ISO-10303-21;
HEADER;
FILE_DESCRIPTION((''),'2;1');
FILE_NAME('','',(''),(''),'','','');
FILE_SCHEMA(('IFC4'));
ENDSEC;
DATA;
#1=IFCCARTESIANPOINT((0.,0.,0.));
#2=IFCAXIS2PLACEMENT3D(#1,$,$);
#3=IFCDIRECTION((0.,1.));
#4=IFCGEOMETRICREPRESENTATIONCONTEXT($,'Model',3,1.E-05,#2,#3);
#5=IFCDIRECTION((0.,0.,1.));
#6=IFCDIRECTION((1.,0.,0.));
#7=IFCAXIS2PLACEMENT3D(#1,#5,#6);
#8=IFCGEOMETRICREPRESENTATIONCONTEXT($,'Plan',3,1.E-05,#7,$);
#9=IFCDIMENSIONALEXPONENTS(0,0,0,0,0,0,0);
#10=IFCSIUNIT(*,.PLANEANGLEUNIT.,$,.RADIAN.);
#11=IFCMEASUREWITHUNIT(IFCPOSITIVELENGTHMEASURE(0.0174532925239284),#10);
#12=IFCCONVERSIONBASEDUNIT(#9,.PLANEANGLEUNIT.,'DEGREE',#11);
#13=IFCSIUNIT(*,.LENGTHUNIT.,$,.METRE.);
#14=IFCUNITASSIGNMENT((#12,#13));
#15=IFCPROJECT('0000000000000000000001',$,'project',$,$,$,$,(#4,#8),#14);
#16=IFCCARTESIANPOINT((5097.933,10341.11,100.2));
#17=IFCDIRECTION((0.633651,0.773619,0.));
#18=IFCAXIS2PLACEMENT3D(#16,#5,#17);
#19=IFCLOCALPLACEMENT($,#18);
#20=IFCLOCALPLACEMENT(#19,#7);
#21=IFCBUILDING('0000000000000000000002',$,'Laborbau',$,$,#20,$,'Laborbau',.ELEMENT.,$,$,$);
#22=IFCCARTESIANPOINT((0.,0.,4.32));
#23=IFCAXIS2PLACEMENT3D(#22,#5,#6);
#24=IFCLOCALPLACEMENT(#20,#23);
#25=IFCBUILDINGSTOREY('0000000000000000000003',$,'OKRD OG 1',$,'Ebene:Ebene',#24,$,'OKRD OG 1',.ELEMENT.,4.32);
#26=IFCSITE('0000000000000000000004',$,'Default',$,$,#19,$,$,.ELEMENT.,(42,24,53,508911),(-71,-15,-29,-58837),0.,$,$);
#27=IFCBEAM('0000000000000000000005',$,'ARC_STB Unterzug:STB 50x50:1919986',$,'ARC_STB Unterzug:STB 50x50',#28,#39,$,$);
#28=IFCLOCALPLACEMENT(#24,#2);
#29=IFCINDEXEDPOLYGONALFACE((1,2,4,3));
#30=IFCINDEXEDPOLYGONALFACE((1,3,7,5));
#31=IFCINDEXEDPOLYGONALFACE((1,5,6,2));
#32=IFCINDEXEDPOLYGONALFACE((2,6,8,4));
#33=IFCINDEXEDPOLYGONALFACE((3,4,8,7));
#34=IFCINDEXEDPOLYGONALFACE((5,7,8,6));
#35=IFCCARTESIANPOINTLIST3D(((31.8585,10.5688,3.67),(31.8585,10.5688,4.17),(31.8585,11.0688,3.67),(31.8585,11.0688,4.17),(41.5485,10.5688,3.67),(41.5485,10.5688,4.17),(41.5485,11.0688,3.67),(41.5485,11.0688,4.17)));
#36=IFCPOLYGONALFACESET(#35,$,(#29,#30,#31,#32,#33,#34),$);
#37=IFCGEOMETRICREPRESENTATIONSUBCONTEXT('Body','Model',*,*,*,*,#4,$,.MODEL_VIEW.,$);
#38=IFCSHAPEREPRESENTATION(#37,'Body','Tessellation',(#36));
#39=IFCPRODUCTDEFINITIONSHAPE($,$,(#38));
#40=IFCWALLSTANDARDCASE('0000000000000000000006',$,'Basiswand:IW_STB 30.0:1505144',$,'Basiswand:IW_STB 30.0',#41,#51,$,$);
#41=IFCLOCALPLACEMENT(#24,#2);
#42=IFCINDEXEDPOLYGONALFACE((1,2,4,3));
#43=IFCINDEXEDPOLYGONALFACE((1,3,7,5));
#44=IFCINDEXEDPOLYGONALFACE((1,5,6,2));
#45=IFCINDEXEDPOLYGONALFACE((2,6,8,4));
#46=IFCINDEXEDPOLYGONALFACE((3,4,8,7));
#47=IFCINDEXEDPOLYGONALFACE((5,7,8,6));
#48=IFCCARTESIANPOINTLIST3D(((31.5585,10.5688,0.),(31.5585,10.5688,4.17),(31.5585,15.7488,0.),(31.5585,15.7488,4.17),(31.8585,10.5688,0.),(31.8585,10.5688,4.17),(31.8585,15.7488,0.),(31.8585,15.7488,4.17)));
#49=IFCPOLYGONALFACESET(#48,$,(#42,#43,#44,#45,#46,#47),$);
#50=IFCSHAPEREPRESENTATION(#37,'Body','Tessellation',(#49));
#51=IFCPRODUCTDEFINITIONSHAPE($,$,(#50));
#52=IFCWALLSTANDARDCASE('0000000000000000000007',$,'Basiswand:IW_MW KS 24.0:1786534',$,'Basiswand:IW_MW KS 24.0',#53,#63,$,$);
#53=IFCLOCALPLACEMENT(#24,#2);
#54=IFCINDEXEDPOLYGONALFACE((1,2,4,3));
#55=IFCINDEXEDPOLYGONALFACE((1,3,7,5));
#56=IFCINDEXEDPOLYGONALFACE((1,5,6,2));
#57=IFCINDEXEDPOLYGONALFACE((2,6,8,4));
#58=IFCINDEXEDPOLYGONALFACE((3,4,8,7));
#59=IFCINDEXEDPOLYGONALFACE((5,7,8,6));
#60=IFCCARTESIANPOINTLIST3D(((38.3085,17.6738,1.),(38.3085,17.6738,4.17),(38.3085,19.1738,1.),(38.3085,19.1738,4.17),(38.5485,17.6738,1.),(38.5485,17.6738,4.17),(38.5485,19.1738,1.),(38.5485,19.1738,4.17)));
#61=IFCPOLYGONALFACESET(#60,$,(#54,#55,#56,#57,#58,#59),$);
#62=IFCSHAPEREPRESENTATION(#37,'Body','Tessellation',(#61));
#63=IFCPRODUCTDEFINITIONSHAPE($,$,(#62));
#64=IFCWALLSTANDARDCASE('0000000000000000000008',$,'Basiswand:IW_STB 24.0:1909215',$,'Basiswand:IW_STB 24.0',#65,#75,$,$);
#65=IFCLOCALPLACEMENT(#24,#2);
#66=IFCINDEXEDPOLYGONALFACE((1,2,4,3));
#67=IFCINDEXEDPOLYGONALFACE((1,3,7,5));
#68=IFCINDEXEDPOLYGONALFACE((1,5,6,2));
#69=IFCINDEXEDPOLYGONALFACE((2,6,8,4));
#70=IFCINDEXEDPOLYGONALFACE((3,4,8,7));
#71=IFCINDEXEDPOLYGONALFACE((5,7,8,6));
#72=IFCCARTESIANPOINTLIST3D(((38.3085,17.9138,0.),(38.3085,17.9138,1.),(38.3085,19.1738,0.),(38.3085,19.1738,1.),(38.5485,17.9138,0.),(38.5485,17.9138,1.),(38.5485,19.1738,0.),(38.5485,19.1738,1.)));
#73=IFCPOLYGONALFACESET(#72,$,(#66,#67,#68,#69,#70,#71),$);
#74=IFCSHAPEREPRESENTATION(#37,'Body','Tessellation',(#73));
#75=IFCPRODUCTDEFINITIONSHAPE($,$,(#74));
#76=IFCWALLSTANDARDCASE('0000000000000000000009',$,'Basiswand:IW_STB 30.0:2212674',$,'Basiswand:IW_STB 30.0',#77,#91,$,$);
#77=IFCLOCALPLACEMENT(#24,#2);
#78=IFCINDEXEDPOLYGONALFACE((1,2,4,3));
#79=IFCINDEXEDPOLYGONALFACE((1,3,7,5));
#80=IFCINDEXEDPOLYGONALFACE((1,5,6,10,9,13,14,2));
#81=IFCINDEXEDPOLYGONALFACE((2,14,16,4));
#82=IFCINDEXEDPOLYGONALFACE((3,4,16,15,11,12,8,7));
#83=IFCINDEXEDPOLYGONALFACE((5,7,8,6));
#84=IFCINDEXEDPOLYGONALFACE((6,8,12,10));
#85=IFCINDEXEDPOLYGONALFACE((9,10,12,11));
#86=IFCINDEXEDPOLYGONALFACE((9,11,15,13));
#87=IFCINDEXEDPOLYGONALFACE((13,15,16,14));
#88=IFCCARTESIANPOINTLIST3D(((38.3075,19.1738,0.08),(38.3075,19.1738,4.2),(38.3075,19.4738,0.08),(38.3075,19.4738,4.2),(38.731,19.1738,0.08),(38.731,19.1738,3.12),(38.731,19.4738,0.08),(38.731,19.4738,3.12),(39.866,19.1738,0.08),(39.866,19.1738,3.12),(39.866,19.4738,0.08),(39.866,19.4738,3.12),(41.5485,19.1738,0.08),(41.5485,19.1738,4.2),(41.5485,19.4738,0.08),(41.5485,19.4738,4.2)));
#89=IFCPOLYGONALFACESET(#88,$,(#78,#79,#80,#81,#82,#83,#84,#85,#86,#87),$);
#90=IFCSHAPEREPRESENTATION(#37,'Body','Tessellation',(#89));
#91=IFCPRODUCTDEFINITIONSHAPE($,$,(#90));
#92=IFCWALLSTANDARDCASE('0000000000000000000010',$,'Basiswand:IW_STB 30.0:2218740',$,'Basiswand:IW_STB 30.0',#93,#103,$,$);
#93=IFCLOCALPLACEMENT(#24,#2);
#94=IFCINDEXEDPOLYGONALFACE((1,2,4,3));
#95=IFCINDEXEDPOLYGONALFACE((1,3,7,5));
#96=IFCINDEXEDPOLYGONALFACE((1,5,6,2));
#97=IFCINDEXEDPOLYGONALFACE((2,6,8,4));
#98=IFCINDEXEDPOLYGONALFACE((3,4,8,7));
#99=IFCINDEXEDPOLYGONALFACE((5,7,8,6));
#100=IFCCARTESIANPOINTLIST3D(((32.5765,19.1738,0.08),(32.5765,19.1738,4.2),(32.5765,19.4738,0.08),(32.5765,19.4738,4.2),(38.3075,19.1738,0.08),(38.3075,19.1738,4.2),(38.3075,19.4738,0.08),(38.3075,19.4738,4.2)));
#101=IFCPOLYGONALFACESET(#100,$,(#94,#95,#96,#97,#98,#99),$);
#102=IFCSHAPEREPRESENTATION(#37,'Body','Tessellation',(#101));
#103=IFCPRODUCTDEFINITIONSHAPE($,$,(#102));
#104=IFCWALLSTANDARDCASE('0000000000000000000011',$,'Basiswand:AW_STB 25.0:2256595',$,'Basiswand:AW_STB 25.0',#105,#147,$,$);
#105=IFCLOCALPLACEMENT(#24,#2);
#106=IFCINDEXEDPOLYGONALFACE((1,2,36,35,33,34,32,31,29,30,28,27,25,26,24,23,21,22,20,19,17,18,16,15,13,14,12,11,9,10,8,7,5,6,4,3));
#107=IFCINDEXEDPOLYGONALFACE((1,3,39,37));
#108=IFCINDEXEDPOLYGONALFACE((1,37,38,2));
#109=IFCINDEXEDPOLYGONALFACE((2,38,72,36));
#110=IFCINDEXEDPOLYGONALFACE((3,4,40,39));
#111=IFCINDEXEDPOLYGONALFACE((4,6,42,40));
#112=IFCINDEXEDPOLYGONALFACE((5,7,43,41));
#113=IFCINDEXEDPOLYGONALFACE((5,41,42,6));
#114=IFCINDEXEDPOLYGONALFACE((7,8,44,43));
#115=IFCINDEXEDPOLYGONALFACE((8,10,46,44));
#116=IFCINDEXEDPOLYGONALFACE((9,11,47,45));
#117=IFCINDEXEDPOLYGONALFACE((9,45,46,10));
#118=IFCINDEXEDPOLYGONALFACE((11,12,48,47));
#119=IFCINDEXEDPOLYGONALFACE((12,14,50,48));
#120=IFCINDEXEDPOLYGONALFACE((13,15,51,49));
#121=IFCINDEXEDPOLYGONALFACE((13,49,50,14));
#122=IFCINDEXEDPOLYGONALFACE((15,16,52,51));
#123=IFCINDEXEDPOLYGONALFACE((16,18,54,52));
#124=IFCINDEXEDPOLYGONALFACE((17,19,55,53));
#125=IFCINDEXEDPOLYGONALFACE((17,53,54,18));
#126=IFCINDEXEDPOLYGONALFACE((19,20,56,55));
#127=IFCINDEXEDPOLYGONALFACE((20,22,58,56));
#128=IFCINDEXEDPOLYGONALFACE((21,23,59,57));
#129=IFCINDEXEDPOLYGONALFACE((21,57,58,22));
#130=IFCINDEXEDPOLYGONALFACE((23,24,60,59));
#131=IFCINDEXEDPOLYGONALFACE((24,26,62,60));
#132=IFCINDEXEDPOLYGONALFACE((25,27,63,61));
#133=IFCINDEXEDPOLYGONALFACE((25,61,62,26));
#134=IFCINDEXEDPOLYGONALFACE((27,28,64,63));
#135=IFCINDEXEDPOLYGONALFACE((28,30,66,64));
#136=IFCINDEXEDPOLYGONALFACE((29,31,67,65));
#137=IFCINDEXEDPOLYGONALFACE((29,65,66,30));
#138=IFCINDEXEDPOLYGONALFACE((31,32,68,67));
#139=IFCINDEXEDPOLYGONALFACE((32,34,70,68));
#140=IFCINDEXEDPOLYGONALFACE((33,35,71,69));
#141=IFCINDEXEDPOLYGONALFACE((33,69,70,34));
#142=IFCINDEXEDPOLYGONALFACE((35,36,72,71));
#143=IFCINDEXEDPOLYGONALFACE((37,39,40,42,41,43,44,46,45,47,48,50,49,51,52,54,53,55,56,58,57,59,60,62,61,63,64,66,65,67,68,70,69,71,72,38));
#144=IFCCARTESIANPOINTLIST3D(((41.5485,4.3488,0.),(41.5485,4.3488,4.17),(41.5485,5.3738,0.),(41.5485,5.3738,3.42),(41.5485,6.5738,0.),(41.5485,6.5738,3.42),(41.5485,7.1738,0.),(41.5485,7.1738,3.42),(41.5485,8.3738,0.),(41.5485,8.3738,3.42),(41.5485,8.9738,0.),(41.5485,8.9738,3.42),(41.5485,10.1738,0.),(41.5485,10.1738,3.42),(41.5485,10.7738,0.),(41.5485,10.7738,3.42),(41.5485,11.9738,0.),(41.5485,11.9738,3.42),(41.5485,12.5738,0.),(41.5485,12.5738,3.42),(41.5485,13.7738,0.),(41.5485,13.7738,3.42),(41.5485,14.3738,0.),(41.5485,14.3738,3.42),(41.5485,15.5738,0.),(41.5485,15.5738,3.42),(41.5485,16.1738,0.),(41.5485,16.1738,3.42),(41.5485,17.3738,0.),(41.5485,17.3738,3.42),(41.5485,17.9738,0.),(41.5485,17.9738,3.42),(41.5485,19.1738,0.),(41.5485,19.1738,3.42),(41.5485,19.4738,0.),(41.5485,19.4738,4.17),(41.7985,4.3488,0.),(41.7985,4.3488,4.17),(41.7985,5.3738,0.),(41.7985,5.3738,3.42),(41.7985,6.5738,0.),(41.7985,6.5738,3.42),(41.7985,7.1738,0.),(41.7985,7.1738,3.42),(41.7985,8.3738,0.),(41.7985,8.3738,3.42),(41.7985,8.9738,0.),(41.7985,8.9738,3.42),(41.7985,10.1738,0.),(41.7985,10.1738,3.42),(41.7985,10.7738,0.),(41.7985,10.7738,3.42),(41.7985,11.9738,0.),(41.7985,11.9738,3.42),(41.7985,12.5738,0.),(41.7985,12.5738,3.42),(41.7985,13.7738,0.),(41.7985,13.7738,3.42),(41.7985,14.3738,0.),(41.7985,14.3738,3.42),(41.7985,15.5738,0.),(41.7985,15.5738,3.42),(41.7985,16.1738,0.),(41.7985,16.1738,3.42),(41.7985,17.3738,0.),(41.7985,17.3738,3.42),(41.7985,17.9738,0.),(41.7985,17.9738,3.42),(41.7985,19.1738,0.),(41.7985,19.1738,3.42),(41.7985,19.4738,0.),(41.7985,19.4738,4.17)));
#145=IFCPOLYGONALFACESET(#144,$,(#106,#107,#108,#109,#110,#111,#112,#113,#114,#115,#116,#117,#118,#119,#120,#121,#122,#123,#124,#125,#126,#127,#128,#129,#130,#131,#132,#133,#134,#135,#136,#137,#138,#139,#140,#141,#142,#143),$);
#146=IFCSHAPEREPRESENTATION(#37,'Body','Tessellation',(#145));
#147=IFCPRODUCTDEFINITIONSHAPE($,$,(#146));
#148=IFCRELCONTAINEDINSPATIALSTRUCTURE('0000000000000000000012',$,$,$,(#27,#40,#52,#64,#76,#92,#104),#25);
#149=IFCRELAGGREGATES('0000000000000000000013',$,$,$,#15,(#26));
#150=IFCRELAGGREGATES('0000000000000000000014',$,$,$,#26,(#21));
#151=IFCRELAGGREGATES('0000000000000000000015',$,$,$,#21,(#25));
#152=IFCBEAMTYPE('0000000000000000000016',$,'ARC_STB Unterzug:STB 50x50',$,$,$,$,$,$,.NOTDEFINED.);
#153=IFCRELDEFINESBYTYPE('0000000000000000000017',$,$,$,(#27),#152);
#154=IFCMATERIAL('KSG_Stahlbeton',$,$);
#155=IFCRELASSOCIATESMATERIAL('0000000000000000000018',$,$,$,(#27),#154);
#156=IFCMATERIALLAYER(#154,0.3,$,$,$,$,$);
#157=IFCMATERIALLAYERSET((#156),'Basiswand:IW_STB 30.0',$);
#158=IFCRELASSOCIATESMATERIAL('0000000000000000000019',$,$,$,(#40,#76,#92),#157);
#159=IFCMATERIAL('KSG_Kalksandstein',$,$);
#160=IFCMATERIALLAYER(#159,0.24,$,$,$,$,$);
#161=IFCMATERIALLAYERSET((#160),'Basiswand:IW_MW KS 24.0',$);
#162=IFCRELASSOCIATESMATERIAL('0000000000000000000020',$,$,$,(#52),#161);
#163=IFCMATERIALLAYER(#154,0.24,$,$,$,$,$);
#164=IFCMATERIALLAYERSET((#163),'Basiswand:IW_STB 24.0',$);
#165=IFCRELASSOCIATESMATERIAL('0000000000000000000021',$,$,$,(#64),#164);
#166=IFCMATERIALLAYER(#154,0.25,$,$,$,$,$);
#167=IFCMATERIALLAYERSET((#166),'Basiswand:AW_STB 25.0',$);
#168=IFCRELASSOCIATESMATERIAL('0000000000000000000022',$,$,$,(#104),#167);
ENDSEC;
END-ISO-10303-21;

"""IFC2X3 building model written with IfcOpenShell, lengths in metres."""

from ifc_helpers import new_model, entity, si_unit, converted_unit, direction, frame, frame_2d, origin, origin_with_axes, place, context, subcontext, project, spatial, rectangle, extrude, material, layer, layer_set, layer_usage, type_object, element, save


model = new_model("IFC2X3")

# Units and contexts
model_context = context("Model", 3, precision=1e-05, world=origin(), true_north=direction((0.0, 1.0)))
plan_context = context("Plan", 3, precision=1e-05, world=origin_with_axes())
body_context = subcontext(model_context, "Body", "Model", "MODEL_VIEW")
ifc_project = project(units=[converted_unit("PLANEANGLEUNIT", "DEGREE", entity("IfcPositiveLengthMeasure", 0.0174532925239284), si_unit("PLANEANGLEUNIT", "RADIAN"), dimensions=[0, 0, 0, 0, 0, 0, 0]), si_unit("LENGTHUNIT", "METRE")], contexts=[model_context, plan_context])

# Site, building, storey
site_placement = place(None, frame((5097.933, 10341.11, 100.2), z_axis=(0.0, 0.0, 1.0), x_axis=(0.633651, 0.773619, 0.0)))
site = spatial("IfcSite", under=ifc_project, at=site_placement, Name="Default", CompositionType="ELEMENT", RefLatitude=(42, 24, 53, 508911), RefLongitude=(-71, -15, -29, -58837), RefElevation=0.0)
building_placement = place(site_placement, origin_with_axes())
building = spatial("IfcBuilding", under=site, at=building_placement, Name="Laborbau", LongName="Laborbau", CompositionType="ELEMENT")
storey_placement = place(building_placement, frame((0.0, 0.0, 4.32), z_axis=(0.0, 0.0, 1.0), x_axis=(1.0, 0.0, 0.0)))
storey = spatial("IfcBuildingStorey", under=building, at=storey_placement, Name="OKRD OG 1", ObjectType="Ebene:Ebene", LongName="OKRD OG 1", CompositionType="ELEMENT", Elevation=4.32)

# Beam
ifc_material_1 = material(Name="KSG_Stahlbeton")
beam_type = type_object("IfcBeamType", Name="ARC_STB Unterzug:STB 50x50", PredefinedType="NOTDEFINED")
beam_placement = place(storey_placement, frame((31.7085, 10.8188, 4.17), z_axis=(0.0, 0.0, 1.0), x_axis=(1.0, 0.0, 0.0)))
element("IfcBeam", 1, at=beam_placement, inside=storey, type_object=beam_type, material=ifc_material_1, Name="ARC_STB Unterzug:STB 50x50:1919986", ObjectType="ARC_STB Unterzug:STB 50x50", context=body_context, shape_type="SweptSolid", body=[
    extrude(rectangle(XDim=0.5, YDim=0.5, at=frame_2d((0.0, 0.0), x_axis=(1.0, 0.0))), frame((0.15, 0.0, -0.25), z_axis=(1.0, 0.0, 0.0), x_axis=(0.0, 0.0, -1.0)), (0.0, 0.0, 1.0), 9.69),
])

# Shared definitions
ifc_layer_1 = layer(ifc_material_1, 0.25)
ifc_layer_set_1 = layer_set([ifc_layer_1], Name="Basiswand:AW_STB 25.0")

# Walls
ifc_layer_2 = layer(ifc_material_1, 0.3)
ifc_layer_set_2 = layer_set([ifc_layer_2], Name="Basiswand:IW_STB 30.0")
ifc_layer_usage_1 = layer_usage(ifc_layer_set_2, "AXIS2", "NEGATIVE", 0.15)
wall_1_placement = place(storey_placement, frame((31.7085, 10.5688, 0.0), z_axis=(0.0, 0.0, 1.0), x_axis=(0.0, 1.0, 0.0)))
element("IfcWallStandardCase", 2, at=wall_1_placement, inside=storey, material=ifc_layer_usage_1, Name="Basiswand:IW_STB 30.0:1505144", ObjectType="Basiswand:IW_STB 30.0", context=body_context, shape_type="SweptSolid", body=[
    extrude(rectangle(XDim=5.18, YDim=0.3, at=frame_2d((2.59, 0.0), x_axis=(-1.0, 0.0))), origin(), (0.0, 0.0, 1.0), 4.17),
])
ifc_material_2 = material(Name="KSG_Kalksandstein")
ifc_layer_3 = layer(ifc_material_2, 0.24)
ifc_layer_set_3 = layer_set([ifc_layer_3], Name="Basiswand:IW_MW KS 24.0")
ifc_layer_usage_2 = layer_usage(ifc_layer_set_3, "AXIS2", "NEGATIVE", 0.12)
wall_2_placement = place(storey_placement, frame((38.4285, 19.1738, 1.0), z_axis=(0.0, 0.0, 1.0), x_axis=(0.0, -1.0, 0.0)))
element("IfcWallStandardCase", 3, at=wall_2_placement, inside=storey, material=ifc_layer_usage_2, Name="Basiswand:IW_MW KS 24.0:1786534", ObjectType="Basiswand:IW_MW KS 24.0", context=body_context, shape_type="SweptSolid", body=[
    extrude(rectangle(XDim=1.5, YDim=0.24, at=frame_2d((0.75, 0.0), x_axis=(-1.0, 0.0))), origin(), (0.0, 0.0, 1.0), 3.17),
])
ifc_layer_4 = layer(ifc_material_1, 0.24)
ifc_layer_set_4 = layer_set([ifc_layer_4], Name="Basiswand:IW_STB 24.0")
ifc_layer_usage_3 = layer_usage(ifc_layer_set_4, "AXIS2", "NEGATIVE", 0.12)
wall_3_placement = place(storey_placement, frame((38.4285, 17.9138, 0.0), z_axis=(0.0, 0.0, 1.0), x_axis=(0.0, 1.0, 0.0)))
element("IfcWallStandardCase", 4, at=wall_3_placement, inside=storey, material=ifc_layer_usage_3, Name="Basiswand:IW_STB 24.0:1909215", ObjectType="Basiswand:IW_STB 24.0", context=body_context, shape_type="SweptSolid", body=[
    extrude(rectangle(XDim=1.26, YDim=0.24, at=frame_2d((0.63, 0.0), x_axis=(-1.0, 0.0))), origin(), (0.0, 0.0, 1.0), 1.0),
])

# Wall, openings
ifc_layer_usage_4 = layer_usage(ifc_layer_set_2, "AXIS2", "POSITIVE", -0.15)
wall_4_placement = place(storey_placement, frame((41.5485, 19.3238, 0.08), z_axis=(0.0, 0.0, 1.0), x_axis=(-1.0, 0.0, 0.0)))
wall_4 = element("IfcWallStandardCase", 5, at=wall_4_placement, inside=storey, material=ifc_layer_usage_4, Name="Basiswand:IW_STB 30.0:2212674", ObjectType="Basiswand:IW_STB 30.0", context=body_context, shape_type="SweptSolid", body=[
    extrude(rectangle(XDim=3.241, YDim=0.3, at=frame_2d((1.6205, 0.0), x_axis=(-1.0, 0.0))), origin(), (0.0, 0.0, 1.0), 4.12),
])
opening_1_placement = place(wall_4_placement, frame((41.5485, 19.3238, -0.08), z_axis=(0.0, 0.0, 1.0), x_axis=(-1.0, 0.0, 0.0)))
element("IfcOpeningElement", 6, at=opening_1_placement, cuts=wall_4, ObjectType="Opening", context=body_context, shape_type="SweptSolid", body=[
    extrude(rectangle(XDim=3.04, YDim=1.135, at=frame_2d((0.0, 0.0), x_axis=(0.0, 1.0))), frame((39.2985, 20.6978, 1.6), z_axis=(0.0, -1.0, 0.0), x_axis=(1.0, 0.0, 0.0)), (0.0, 0.0, 1.0), 3.048),
])
opening_2_placement = place(wall_4_placement, frame((1.6825, -0.15, 0.0), z_axis=(0.0, 0.0, 1.0), x_axis=(1.0, 0.0, 0.0)))
element("IfcOpeningElement", 7, at=opening_2_placement, cuts=wall_4, ObjectType="Opening", context=body_context, shape_type="SweptSolid", body=[
    extrude(rectangle(XDim=3.04, YDim=1.135, at=frame_2d((1.52, 0.5675), x_axis=(1.0, 0.0))), frame((0.0, 0.0, 0.0), z_axis=(0.0, 1.0, 0.0), x_axis=(0.0, 0.0, 1.0)), (0.0, 0.0, 1.0), 0.3),
])

# Wall
ifc_layer_usage_5 = layer_usage(ifc_layer_set_2, "AXIS2", "POSITIVE", -0.15)
wall_5_placement = place(storey_placement, frame((38.3075, 19.3238, 0.08), z_axis=(0.0, 0.0, 1.0), x_axis=(-1.0, 0.0, 0.0)))
element("IfcWallStandardCase", 8, at=wall_5_placement, inside=storey, material=ifc_layer_usage_5, Name="Basiswand:IW_STB 30.0:2218740", ObjectType="Basiswand:IW_STB 30.0", context=body_context, shape_type="SweptSolid", body=[
    extrude(rectangle(XDim=5.731, YDim=0.3, at=frame_2d((2.8655, 0.0), x_axis=(-1.0, 0.0))), origin(), (0.0, 0.0, 1.0), 4.12),
])

# Wall, openings
ifc_layer_usage_6 = layer_usage(ifc_layer_set_1, "AXIS2", "NEGATIVE", 0.125)
wall_6_placement = place(storey_placement, frame((41.6735, 19.4738, 0.0), z_axis=(0.0, 0.0, 1.0), x_axis=(0.0, -1.0, 0.0)))
wall_6 = element("IfcWallStandardCase", 9, at=wall_6_placement, inside=storey, material=ifc_layer_usage_6, Name="Basiswand:AW_STB 25.0:2256595", ObjectType="Basiswand:AW_STB 25.0", context=body_context, shape_type="SweptSolid", body=[
    extrude(rectangle(XDim=15.125, YDim=0.25, at=frame_2d((7.5625, 0.0), x_axis=(-1.0, 0.0))), origin(), (0.0, 0.0, 1.0), 4.17),
])
opening_3_placement = place(wall_6_placement, frame((19.4738, -41.6735, 0.0), z_axis=(0.0, 0.0, 1.0), x_axis=(0.0, 1.0, 0.0)))
element("IfcOpeningElement", 10, at=opening_3_placement, cuts=wall_6, ObjectType="Opening", context=body_context, shape_type="SweptSolid", body=[
    extrude(rectangle(XDim=3.42, YDim=1.2, at=frame_2d((0.0, 0.0), x_axis=(0.0, 1.0))), frame((41.5485, 13.1738, 1.71), z_axis=(1.0, 0.0, 0.0), x_axis=(0.0, -1.0, 0.0)), (0.0, 0.0, 1.0), 0.25),
])
opening_4_placement = place(wall_6_placement, frame((19.4738, -41.6735, 0.0), z_axis=(0.0, 0.0, 1.0), x_axis=(0.0, 1.0, 0.0)))
element("IfcOpeningElement", 11, at=opening_4_placement, cuts=wall_6, ObjectType="Opening", context=body_context, shape_type="SweptSolid", body=[
    extrude(rectangle(XDim=3.42, YDim=1.2, at=frame_2d((0.0, 0.0), x_axis=(1.0, 0.0))), frame((41.5485, 11.3738, 1.71), z_axis=(1.0, 0.0, 0.0), x_axis=(0.0, 0.0, -1.0)), (0.0, 0.0, 1.0), 0.25),
])
opening_5_placement = place(wall_6_placement, frame((19.4738, -41.6735, 0.0), z_axis=(0.0, 0.0, 1.0), x_axis=(0.0, 1.0, 0.0)))
element("IfcOpeningElement", 12, at=opening_5_placement, cuts=wall_6, ObjectType="Opening", context=body_context, shape_type="SweptSolid", body=[
    extrude(rectangle(XDim=3.42, YDim=1.2, at=frame_2d((0.0, 0.0), x_axis=(0.0, 1.0))), frame((41.5485, 9.5738, 1.71), z_axis=(1.0, 0.0, 0.0), x_axis=(0.0, -1.0, 0.0)), (0.0, 0.0, 1.0), 0.25),
])
opening_6_placement = place(wall_6_placement, frame((19.4738, -41.6735, 0.0), z_axis=(0.0, 0.0, 1.0), x_axis=(0.0, 1.0, 0.0)))
element("IfcOpeningElement", 13, at=opening_6_placement, cuts=wall_6, ObjectType="Opening", context=body_context, shape_type="SweptSolid", body=[
    extrude(rectangle(XDim=3.42, YDim=1.2, at=frame_2d((0.0, 0.0), x_axis=(1.0, 0.0))), frame((41.5485, 7.7738, 1.71), z_axis=(1.0, 0.0, 0.0), x_axis=(0.0, 0.0, -1.0)), (0.0, 0.0, 1.0), 0.25),
])
opening_7_placement = place(wall_6_placement, frame((19.4738, -41.6735, 0.0), z_axis=(0.0, 0.0, 1.0), x_axis=(0.0, 1.0, 0.0)))
element("IfcOpeningElement", 14, at=opening_7_placement, cuts=wall_6, ObjectType="Opening", context=body_context, shape_type="SweptSolid", body=[
    extrude(rectangle(XDim=3.42, YDim=1.2, at=frame_2d((0.0, 0.0), x_axis=(0.0, 1.0))), frame((41.5485, 5.9738, 1.71), z_axis=(1.0, 0.0, 0.0), x_axis=(0.0, -1.0, 0.0)), (0.0, 0.0, 1.0), 0.25),
])
opening_8_placement = place(wall_6_placement, frame((19.4738, -41.6735, 0.0), z_axis=(0.0, 0.0, 1.0), x_axis=(0.0, 1.0, 0.0)))
element("IfcOpeningElement", 15, at=opening_8_placement, cuts=wall_6, ObjectType="Opening", context=body_context, shape_type="SweptSolid", body=[
    extrude(rectangle(XDim=3.42, YDim=1.2, at=frame_2d((0.0, 0.0), x_axis=(1.0, 0.0))), frame((41.5485, 18.5738, 1.71), z_axis=(1.0, 0.0, 0.0), x_axis=(0.0, 0.0, -1.0)), (0.0, 0.0, 1.0), 0.25),
])
opening_9_placement = place(wall_6_placement, frame((19.4738, -41.6735, 0.0), z_axis=(0.0, 0.0, 1.0), x_axis=(0.0, 1.0, 0.0)))
element("IfcOpeningElement", 16, at=opening_9_placement, cuts=wall_6, ObjectType="Opening", context=body_context, shape_type="SweptSolid", body=[
    extrude(rectangle(XDim=3.42, YDim=1.2, at=frame_2d((0.0, 0.0), x_axis=(0.0, 1.0))), frame((41.5485, 16.7738, 1.71), z_axis=(1.0, 0.0, 0.0), x_axis=(0.0, -1.0, 0.0)), (0.0, 0.0, 1.0), 0.25),
])
opening_10_placement = place(wall_6_placement, frame((19.4738, -41.6735, 0.0), z_axis=(0.0, 0.0, 1.0), x_axis=(0.0, 1.0, 0.0)))
element("IfcOpeningElement", 17, at=opening_10_placement, cuts=wall_6, ObjectType="Opening", context=body_context, shape_type="SweptSolid", body=[
    extrude(rectangle(XDim=3.42, YDim=1.2, at=frame_2d((0.0, 0.0), x_axis=(1.0, 0.0))), frame((41.5485, 14.9738, 1.71), z_axis=(1.0, 0.0, 0.0), x_axis=(0.0, 0.0, -1.0)), (0.0, 0.0, 1.0), 0.25),
])

save(model, "model.ifc")
